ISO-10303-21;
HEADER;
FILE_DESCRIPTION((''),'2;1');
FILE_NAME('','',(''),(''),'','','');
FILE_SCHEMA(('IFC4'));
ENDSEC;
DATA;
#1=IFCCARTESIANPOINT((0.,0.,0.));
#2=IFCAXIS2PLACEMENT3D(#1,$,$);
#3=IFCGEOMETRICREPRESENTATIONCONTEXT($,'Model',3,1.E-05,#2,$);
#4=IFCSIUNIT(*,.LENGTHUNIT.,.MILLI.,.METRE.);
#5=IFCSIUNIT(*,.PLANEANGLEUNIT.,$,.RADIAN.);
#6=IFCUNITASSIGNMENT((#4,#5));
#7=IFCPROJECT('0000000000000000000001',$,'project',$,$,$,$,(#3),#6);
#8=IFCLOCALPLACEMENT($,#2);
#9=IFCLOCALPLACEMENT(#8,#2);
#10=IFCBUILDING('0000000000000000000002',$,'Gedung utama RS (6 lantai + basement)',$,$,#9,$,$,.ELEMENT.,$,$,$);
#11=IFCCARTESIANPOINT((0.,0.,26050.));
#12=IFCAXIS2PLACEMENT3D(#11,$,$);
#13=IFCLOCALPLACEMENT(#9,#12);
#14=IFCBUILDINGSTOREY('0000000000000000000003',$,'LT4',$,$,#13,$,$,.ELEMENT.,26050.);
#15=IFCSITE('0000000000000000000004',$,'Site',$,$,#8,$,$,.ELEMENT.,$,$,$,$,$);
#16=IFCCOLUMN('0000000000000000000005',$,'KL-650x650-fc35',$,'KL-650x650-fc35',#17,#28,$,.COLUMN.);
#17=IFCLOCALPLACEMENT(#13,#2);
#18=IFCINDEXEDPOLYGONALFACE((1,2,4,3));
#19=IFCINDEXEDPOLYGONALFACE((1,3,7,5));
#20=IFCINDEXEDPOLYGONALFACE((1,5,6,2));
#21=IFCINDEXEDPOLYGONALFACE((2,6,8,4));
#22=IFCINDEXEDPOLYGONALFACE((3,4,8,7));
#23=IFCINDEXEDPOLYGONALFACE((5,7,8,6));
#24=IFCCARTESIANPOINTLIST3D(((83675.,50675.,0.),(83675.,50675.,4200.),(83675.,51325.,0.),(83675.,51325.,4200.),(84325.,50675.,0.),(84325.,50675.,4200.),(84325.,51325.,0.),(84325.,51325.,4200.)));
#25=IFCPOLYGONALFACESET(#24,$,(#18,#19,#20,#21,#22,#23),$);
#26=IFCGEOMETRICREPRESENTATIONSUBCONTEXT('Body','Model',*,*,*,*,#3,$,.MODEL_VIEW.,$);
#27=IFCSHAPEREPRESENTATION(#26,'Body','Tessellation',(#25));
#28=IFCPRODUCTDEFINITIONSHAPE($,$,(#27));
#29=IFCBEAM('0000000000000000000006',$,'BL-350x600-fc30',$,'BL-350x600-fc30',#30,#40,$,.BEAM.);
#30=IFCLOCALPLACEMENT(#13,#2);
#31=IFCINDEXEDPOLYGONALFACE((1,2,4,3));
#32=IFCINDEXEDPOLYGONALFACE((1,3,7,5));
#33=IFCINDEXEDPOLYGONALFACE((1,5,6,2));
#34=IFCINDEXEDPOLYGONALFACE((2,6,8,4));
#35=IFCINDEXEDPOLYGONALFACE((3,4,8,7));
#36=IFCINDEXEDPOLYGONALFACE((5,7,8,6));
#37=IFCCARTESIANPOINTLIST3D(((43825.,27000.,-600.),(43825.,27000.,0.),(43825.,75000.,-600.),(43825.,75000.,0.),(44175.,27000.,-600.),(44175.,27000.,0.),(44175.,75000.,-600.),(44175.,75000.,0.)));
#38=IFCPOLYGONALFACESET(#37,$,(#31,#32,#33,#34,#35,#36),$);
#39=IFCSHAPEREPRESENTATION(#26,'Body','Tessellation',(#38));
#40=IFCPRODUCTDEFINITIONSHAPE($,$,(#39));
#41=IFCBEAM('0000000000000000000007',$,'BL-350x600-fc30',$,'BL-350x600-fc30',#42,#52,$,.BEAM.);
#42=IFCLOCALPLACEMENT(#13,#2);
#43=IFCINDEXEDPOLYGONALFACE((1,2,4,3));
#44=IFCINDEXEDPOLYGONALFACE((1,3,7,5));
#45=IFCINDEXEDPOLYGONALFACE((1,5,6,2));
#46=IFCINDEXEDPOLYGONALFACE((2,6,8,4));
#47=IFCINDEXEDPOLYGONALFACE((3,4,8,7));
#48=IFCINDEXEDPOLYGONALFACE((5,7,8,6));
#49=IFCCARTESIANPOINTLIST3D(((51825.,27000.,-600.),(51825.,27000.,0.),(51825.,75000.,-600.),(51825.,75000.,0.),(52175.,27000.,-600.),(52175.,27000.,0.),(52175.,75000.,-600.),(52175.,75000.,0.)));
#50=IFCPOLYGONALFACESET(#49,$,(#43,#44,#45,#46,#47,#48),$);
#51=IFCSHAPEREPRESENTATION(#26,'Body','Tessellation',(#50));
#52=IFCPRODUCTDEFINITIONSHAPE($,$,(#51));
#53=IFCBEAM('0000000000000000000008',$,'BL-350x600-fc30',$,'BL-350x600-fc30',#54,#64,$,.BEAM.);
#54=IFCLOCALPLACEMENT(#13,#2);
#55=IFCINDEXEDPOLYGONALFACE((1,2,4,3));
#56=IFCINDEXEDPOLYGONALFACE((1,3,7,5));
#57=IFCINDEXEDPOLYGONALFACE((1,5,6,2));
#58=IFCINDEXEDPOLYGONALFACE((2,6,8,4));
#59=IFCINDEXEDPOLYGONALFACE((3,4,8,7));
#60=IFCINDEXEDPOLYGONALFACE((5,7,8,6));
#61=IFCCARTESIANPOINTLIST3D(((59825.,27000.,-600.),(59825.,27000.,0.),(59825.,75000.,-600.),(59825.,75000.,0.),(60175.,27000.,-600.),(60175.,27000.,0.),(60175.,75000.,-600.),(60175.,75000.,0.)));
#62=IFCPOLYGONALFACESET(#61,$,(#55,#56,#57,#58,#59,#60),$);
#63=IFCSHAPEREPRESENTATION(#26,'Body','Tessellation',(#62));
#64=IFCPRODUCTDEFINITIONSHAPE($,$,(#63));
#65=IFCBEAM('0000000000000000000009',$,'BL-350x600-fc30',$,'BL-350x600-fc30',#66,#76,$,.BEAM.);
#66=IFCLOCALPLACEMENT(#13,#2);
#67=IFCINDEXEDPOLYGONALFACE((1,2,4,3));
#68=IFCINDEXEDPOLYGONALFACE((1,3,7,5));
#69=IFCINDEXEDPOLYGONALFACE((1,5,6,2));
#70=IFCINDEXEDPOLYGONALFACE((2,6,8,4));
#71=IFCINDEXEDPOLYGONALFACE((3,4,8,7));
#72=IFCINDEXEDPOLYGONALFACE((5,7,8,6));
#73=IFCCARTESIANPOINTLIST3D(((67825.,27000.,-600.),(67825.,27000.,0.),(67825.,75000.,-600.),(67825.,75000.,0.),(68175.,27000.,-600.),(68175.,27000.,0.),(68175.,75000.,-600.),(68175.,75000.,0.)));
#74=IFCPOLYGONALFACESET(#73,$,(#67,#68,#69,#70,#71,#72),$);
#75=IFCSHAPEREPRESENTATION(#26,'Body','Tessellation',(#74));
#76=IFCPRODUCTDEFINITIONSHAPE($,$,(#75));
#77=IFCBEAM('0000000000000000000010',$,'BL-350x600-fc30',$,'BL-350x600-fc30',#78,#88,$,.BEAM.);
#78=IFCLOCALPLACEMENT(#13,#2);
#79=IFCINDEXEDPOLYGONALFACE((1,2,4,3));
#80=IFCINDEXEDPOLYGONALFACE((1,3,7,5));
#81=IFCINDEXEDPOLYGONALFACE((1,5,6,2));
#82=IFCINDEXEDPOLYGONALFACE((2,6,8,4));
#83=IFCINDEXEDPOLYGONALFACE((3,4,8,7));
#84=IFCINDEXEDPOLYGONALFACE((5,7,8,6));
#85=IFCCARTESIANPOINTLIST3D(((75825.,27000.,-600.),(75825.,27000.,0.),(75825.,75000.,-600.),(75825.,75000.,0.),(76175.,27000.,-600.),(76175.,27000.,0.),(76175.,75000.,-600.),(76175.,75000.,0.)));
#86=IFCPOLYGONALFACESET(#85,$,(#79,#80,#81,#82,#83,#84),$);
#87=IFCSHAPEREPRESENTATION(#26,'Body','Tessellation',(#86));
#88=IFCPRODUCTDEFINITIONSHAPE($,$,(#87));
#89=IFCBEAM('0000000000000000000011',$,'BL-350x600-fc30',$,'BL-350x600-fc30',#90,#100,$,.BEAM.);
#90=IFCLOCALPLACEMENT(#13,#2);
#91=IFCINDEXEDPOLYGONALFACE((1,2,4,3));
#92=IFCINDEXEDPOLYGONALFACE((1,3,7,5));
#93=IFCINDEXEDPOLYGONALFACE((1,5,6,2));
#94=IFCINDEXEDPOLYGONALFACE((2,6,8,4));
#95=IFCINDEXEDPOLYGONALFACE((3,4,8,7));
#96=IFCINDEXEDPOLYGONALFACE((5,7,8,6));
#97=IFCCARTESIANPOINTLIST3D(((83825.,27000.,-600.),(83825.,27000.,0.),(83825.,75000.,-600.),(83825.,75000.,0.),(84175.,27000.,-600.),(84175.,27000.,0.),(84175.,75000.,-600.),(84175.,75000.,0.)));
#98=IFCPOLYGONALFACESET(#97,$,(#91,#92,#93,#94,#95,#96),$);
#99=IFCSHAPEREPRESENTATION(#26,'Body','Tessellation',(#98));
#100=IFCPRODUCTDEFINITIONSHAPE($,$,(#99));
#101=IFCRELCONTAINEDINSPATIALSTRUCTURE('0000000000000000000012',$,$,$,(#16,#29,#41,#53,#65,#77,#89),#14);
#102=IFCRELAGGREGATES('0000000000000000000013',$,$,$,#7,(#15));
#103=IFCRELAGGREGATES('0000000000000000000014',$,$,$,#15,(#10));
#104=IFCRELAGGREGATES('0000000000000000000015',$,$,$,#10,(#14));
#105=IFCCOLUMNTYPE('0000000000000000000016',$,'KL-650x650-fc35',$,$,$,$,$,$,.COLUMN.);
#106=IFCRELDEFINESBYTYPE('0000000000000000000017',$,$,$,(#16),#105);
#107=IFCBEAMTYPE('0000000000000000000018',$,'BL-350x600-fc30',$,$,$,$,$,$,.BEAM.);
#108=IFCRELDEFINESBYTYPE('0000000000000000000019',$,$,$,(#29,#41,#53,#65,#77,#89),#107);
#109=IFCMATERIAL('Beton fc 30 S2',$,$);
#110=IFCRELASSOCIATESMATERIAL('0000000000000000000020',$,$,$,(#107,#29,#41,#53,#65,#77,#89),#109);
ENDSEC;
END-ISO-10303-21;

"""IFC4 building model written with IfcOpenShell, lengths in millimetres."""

from ifc_helpers import new_model, si_unit, frame, origin, origin_2d, place, context, subcontext, project, spatial, rectangle, extrude, material, material_profile, profile_set, profile_usage, type_object, element, save


model = new_model("IFC4")

# Units and contexts
model_context = context("Model", 3, precision=1e-05, world=origin())
body_context = subcontext(model_context, "Body", "Model", "MODEL_VIEW")
ifc_project = project(units=[si_unit("LENGTHUNIT", "METRE", prefix="MILLI"), si_unit("PLANEANGLEUNIT", "RADIAN")], contexts=[model_context])

# Site, building, storey
site_placement = place(None, origin())
site = spatial("IfcSite", under=ifc_project, at=site_placement, Name="Site", CompositionType="ELEMENT")
building_placement = place(site_placement, origin())
building = spatial("IfcBuilding", under=site, at=building_placement, Name="Gedung utama RS (6 lantai + basement)", CompositionType="ELEMENT")
storey_placement = place(building_placement, frame((0.0, 0.0, 26050.0)))
storey = spatial("IfcBuildingStorey", under=building, at=storey_placement, Name="LT4", CompositionType="ELEMENT", Elevation=26050.0)

# Column
ifc_material_profile_1 = material_profile(None, rectangle(XDim=650.0, YDim=650.0, at=origin_2d()), Name="KL-650x650-fc35")
ifc_profile_set_1 = profile_set([ifc_material_profile_1], Name="KL-650x650-fc35")
ifc_profile_usage_1 = profile_usage(ifc_profile_set_1, cardinal=5)
column_type = type_object("IfcColumnType", Name="KL-650x650-fc35", PredefinedType="COLUMN", material=ifc_profile_set_1)
for number, where, z_axis, x_axis, name in (
    (1, (84000.0, 51000.0, 0.0), (0.0, 0.0, 1.0), (1.0, 0.0, 0.0), "KL-650x650-fc35"),
):
    element("IfcColumn", number, at=place(storey_placement, frame(where, z_axis=z_axis, x_axis=x_axis)), inside=storey, type_object=column_type, material=ifc_profile_usage_1, Name=name, ObjectType="KL-650x650-fc35", PredefinedType="COLUMN", context=body_context, shape_type="SweptSolid", body=[
        extrude(rectangle(XDim=650.0, YDim=650.0, at=origin_2d()), origin(), (0.0, 0.0, 1.0), 4200.0),
    ])

# Beams
ifc_material = material(Name="Beton fc 30 S2")
ifc_material_profile_2 = material_profile(ifc_material, rectangle(XDim=350.0, YDim=600.0, at=origin_2d()), Name="BL-350x600-fc30")
ifc_profile_set_2 = profile_set([ifc_material_profile_2], Name="BL-350x600-fc30")
ifc_profile_usage_2 = profile_usage(ifc_profile_set_2, cardinal=8)
beam_type = type_object("IfcBeamType", Name="BL-350x600-fc30", PredefinedType="BEAM", material=ifc_profile_set_2)
for number, where, name in (
    (2, (44000.0, 27000.0, -300.0), "BL-350x600-fc30"),
    (3, (52000.0, 27000.0, -300.0), "BL-350x600-fc30"),
    (4, (60000.0, 27000.0, -300.0), "BL-350x600-fc30"),
    (5, (68000.0, 27000.0, -300.0), "BL-350x600-fc30"),
    (6, (76000.0, 27000.0, -300.0), "BL-350x600-fc30"),
    (7, (84000.0, 27000.0, -300.0), "BL-350x600-fc30"),
):
    element("IfcBeam", number, at=place(storey_placement, frame(where)), inside=storey, type_object=beam_type, material=ifc_profile_usage_2, Name=name, ObjectType="BL-350x600-fc30", PredefinedType="BEAM", context=body_context, shape_type="SweptSolid", body=[
        extrude(rectangle(XDim=350.0, YDim=600.0, at=origin_2d()), frame((0.0, 0.0, 0.0), z_axis=(0.0, 1.0, 0.0), x_axis=(-1.0, 0.0, 0.0)), (0.0, 0.0, 1.0), 48000.0),
    ])

save(model, "model.ifc")
